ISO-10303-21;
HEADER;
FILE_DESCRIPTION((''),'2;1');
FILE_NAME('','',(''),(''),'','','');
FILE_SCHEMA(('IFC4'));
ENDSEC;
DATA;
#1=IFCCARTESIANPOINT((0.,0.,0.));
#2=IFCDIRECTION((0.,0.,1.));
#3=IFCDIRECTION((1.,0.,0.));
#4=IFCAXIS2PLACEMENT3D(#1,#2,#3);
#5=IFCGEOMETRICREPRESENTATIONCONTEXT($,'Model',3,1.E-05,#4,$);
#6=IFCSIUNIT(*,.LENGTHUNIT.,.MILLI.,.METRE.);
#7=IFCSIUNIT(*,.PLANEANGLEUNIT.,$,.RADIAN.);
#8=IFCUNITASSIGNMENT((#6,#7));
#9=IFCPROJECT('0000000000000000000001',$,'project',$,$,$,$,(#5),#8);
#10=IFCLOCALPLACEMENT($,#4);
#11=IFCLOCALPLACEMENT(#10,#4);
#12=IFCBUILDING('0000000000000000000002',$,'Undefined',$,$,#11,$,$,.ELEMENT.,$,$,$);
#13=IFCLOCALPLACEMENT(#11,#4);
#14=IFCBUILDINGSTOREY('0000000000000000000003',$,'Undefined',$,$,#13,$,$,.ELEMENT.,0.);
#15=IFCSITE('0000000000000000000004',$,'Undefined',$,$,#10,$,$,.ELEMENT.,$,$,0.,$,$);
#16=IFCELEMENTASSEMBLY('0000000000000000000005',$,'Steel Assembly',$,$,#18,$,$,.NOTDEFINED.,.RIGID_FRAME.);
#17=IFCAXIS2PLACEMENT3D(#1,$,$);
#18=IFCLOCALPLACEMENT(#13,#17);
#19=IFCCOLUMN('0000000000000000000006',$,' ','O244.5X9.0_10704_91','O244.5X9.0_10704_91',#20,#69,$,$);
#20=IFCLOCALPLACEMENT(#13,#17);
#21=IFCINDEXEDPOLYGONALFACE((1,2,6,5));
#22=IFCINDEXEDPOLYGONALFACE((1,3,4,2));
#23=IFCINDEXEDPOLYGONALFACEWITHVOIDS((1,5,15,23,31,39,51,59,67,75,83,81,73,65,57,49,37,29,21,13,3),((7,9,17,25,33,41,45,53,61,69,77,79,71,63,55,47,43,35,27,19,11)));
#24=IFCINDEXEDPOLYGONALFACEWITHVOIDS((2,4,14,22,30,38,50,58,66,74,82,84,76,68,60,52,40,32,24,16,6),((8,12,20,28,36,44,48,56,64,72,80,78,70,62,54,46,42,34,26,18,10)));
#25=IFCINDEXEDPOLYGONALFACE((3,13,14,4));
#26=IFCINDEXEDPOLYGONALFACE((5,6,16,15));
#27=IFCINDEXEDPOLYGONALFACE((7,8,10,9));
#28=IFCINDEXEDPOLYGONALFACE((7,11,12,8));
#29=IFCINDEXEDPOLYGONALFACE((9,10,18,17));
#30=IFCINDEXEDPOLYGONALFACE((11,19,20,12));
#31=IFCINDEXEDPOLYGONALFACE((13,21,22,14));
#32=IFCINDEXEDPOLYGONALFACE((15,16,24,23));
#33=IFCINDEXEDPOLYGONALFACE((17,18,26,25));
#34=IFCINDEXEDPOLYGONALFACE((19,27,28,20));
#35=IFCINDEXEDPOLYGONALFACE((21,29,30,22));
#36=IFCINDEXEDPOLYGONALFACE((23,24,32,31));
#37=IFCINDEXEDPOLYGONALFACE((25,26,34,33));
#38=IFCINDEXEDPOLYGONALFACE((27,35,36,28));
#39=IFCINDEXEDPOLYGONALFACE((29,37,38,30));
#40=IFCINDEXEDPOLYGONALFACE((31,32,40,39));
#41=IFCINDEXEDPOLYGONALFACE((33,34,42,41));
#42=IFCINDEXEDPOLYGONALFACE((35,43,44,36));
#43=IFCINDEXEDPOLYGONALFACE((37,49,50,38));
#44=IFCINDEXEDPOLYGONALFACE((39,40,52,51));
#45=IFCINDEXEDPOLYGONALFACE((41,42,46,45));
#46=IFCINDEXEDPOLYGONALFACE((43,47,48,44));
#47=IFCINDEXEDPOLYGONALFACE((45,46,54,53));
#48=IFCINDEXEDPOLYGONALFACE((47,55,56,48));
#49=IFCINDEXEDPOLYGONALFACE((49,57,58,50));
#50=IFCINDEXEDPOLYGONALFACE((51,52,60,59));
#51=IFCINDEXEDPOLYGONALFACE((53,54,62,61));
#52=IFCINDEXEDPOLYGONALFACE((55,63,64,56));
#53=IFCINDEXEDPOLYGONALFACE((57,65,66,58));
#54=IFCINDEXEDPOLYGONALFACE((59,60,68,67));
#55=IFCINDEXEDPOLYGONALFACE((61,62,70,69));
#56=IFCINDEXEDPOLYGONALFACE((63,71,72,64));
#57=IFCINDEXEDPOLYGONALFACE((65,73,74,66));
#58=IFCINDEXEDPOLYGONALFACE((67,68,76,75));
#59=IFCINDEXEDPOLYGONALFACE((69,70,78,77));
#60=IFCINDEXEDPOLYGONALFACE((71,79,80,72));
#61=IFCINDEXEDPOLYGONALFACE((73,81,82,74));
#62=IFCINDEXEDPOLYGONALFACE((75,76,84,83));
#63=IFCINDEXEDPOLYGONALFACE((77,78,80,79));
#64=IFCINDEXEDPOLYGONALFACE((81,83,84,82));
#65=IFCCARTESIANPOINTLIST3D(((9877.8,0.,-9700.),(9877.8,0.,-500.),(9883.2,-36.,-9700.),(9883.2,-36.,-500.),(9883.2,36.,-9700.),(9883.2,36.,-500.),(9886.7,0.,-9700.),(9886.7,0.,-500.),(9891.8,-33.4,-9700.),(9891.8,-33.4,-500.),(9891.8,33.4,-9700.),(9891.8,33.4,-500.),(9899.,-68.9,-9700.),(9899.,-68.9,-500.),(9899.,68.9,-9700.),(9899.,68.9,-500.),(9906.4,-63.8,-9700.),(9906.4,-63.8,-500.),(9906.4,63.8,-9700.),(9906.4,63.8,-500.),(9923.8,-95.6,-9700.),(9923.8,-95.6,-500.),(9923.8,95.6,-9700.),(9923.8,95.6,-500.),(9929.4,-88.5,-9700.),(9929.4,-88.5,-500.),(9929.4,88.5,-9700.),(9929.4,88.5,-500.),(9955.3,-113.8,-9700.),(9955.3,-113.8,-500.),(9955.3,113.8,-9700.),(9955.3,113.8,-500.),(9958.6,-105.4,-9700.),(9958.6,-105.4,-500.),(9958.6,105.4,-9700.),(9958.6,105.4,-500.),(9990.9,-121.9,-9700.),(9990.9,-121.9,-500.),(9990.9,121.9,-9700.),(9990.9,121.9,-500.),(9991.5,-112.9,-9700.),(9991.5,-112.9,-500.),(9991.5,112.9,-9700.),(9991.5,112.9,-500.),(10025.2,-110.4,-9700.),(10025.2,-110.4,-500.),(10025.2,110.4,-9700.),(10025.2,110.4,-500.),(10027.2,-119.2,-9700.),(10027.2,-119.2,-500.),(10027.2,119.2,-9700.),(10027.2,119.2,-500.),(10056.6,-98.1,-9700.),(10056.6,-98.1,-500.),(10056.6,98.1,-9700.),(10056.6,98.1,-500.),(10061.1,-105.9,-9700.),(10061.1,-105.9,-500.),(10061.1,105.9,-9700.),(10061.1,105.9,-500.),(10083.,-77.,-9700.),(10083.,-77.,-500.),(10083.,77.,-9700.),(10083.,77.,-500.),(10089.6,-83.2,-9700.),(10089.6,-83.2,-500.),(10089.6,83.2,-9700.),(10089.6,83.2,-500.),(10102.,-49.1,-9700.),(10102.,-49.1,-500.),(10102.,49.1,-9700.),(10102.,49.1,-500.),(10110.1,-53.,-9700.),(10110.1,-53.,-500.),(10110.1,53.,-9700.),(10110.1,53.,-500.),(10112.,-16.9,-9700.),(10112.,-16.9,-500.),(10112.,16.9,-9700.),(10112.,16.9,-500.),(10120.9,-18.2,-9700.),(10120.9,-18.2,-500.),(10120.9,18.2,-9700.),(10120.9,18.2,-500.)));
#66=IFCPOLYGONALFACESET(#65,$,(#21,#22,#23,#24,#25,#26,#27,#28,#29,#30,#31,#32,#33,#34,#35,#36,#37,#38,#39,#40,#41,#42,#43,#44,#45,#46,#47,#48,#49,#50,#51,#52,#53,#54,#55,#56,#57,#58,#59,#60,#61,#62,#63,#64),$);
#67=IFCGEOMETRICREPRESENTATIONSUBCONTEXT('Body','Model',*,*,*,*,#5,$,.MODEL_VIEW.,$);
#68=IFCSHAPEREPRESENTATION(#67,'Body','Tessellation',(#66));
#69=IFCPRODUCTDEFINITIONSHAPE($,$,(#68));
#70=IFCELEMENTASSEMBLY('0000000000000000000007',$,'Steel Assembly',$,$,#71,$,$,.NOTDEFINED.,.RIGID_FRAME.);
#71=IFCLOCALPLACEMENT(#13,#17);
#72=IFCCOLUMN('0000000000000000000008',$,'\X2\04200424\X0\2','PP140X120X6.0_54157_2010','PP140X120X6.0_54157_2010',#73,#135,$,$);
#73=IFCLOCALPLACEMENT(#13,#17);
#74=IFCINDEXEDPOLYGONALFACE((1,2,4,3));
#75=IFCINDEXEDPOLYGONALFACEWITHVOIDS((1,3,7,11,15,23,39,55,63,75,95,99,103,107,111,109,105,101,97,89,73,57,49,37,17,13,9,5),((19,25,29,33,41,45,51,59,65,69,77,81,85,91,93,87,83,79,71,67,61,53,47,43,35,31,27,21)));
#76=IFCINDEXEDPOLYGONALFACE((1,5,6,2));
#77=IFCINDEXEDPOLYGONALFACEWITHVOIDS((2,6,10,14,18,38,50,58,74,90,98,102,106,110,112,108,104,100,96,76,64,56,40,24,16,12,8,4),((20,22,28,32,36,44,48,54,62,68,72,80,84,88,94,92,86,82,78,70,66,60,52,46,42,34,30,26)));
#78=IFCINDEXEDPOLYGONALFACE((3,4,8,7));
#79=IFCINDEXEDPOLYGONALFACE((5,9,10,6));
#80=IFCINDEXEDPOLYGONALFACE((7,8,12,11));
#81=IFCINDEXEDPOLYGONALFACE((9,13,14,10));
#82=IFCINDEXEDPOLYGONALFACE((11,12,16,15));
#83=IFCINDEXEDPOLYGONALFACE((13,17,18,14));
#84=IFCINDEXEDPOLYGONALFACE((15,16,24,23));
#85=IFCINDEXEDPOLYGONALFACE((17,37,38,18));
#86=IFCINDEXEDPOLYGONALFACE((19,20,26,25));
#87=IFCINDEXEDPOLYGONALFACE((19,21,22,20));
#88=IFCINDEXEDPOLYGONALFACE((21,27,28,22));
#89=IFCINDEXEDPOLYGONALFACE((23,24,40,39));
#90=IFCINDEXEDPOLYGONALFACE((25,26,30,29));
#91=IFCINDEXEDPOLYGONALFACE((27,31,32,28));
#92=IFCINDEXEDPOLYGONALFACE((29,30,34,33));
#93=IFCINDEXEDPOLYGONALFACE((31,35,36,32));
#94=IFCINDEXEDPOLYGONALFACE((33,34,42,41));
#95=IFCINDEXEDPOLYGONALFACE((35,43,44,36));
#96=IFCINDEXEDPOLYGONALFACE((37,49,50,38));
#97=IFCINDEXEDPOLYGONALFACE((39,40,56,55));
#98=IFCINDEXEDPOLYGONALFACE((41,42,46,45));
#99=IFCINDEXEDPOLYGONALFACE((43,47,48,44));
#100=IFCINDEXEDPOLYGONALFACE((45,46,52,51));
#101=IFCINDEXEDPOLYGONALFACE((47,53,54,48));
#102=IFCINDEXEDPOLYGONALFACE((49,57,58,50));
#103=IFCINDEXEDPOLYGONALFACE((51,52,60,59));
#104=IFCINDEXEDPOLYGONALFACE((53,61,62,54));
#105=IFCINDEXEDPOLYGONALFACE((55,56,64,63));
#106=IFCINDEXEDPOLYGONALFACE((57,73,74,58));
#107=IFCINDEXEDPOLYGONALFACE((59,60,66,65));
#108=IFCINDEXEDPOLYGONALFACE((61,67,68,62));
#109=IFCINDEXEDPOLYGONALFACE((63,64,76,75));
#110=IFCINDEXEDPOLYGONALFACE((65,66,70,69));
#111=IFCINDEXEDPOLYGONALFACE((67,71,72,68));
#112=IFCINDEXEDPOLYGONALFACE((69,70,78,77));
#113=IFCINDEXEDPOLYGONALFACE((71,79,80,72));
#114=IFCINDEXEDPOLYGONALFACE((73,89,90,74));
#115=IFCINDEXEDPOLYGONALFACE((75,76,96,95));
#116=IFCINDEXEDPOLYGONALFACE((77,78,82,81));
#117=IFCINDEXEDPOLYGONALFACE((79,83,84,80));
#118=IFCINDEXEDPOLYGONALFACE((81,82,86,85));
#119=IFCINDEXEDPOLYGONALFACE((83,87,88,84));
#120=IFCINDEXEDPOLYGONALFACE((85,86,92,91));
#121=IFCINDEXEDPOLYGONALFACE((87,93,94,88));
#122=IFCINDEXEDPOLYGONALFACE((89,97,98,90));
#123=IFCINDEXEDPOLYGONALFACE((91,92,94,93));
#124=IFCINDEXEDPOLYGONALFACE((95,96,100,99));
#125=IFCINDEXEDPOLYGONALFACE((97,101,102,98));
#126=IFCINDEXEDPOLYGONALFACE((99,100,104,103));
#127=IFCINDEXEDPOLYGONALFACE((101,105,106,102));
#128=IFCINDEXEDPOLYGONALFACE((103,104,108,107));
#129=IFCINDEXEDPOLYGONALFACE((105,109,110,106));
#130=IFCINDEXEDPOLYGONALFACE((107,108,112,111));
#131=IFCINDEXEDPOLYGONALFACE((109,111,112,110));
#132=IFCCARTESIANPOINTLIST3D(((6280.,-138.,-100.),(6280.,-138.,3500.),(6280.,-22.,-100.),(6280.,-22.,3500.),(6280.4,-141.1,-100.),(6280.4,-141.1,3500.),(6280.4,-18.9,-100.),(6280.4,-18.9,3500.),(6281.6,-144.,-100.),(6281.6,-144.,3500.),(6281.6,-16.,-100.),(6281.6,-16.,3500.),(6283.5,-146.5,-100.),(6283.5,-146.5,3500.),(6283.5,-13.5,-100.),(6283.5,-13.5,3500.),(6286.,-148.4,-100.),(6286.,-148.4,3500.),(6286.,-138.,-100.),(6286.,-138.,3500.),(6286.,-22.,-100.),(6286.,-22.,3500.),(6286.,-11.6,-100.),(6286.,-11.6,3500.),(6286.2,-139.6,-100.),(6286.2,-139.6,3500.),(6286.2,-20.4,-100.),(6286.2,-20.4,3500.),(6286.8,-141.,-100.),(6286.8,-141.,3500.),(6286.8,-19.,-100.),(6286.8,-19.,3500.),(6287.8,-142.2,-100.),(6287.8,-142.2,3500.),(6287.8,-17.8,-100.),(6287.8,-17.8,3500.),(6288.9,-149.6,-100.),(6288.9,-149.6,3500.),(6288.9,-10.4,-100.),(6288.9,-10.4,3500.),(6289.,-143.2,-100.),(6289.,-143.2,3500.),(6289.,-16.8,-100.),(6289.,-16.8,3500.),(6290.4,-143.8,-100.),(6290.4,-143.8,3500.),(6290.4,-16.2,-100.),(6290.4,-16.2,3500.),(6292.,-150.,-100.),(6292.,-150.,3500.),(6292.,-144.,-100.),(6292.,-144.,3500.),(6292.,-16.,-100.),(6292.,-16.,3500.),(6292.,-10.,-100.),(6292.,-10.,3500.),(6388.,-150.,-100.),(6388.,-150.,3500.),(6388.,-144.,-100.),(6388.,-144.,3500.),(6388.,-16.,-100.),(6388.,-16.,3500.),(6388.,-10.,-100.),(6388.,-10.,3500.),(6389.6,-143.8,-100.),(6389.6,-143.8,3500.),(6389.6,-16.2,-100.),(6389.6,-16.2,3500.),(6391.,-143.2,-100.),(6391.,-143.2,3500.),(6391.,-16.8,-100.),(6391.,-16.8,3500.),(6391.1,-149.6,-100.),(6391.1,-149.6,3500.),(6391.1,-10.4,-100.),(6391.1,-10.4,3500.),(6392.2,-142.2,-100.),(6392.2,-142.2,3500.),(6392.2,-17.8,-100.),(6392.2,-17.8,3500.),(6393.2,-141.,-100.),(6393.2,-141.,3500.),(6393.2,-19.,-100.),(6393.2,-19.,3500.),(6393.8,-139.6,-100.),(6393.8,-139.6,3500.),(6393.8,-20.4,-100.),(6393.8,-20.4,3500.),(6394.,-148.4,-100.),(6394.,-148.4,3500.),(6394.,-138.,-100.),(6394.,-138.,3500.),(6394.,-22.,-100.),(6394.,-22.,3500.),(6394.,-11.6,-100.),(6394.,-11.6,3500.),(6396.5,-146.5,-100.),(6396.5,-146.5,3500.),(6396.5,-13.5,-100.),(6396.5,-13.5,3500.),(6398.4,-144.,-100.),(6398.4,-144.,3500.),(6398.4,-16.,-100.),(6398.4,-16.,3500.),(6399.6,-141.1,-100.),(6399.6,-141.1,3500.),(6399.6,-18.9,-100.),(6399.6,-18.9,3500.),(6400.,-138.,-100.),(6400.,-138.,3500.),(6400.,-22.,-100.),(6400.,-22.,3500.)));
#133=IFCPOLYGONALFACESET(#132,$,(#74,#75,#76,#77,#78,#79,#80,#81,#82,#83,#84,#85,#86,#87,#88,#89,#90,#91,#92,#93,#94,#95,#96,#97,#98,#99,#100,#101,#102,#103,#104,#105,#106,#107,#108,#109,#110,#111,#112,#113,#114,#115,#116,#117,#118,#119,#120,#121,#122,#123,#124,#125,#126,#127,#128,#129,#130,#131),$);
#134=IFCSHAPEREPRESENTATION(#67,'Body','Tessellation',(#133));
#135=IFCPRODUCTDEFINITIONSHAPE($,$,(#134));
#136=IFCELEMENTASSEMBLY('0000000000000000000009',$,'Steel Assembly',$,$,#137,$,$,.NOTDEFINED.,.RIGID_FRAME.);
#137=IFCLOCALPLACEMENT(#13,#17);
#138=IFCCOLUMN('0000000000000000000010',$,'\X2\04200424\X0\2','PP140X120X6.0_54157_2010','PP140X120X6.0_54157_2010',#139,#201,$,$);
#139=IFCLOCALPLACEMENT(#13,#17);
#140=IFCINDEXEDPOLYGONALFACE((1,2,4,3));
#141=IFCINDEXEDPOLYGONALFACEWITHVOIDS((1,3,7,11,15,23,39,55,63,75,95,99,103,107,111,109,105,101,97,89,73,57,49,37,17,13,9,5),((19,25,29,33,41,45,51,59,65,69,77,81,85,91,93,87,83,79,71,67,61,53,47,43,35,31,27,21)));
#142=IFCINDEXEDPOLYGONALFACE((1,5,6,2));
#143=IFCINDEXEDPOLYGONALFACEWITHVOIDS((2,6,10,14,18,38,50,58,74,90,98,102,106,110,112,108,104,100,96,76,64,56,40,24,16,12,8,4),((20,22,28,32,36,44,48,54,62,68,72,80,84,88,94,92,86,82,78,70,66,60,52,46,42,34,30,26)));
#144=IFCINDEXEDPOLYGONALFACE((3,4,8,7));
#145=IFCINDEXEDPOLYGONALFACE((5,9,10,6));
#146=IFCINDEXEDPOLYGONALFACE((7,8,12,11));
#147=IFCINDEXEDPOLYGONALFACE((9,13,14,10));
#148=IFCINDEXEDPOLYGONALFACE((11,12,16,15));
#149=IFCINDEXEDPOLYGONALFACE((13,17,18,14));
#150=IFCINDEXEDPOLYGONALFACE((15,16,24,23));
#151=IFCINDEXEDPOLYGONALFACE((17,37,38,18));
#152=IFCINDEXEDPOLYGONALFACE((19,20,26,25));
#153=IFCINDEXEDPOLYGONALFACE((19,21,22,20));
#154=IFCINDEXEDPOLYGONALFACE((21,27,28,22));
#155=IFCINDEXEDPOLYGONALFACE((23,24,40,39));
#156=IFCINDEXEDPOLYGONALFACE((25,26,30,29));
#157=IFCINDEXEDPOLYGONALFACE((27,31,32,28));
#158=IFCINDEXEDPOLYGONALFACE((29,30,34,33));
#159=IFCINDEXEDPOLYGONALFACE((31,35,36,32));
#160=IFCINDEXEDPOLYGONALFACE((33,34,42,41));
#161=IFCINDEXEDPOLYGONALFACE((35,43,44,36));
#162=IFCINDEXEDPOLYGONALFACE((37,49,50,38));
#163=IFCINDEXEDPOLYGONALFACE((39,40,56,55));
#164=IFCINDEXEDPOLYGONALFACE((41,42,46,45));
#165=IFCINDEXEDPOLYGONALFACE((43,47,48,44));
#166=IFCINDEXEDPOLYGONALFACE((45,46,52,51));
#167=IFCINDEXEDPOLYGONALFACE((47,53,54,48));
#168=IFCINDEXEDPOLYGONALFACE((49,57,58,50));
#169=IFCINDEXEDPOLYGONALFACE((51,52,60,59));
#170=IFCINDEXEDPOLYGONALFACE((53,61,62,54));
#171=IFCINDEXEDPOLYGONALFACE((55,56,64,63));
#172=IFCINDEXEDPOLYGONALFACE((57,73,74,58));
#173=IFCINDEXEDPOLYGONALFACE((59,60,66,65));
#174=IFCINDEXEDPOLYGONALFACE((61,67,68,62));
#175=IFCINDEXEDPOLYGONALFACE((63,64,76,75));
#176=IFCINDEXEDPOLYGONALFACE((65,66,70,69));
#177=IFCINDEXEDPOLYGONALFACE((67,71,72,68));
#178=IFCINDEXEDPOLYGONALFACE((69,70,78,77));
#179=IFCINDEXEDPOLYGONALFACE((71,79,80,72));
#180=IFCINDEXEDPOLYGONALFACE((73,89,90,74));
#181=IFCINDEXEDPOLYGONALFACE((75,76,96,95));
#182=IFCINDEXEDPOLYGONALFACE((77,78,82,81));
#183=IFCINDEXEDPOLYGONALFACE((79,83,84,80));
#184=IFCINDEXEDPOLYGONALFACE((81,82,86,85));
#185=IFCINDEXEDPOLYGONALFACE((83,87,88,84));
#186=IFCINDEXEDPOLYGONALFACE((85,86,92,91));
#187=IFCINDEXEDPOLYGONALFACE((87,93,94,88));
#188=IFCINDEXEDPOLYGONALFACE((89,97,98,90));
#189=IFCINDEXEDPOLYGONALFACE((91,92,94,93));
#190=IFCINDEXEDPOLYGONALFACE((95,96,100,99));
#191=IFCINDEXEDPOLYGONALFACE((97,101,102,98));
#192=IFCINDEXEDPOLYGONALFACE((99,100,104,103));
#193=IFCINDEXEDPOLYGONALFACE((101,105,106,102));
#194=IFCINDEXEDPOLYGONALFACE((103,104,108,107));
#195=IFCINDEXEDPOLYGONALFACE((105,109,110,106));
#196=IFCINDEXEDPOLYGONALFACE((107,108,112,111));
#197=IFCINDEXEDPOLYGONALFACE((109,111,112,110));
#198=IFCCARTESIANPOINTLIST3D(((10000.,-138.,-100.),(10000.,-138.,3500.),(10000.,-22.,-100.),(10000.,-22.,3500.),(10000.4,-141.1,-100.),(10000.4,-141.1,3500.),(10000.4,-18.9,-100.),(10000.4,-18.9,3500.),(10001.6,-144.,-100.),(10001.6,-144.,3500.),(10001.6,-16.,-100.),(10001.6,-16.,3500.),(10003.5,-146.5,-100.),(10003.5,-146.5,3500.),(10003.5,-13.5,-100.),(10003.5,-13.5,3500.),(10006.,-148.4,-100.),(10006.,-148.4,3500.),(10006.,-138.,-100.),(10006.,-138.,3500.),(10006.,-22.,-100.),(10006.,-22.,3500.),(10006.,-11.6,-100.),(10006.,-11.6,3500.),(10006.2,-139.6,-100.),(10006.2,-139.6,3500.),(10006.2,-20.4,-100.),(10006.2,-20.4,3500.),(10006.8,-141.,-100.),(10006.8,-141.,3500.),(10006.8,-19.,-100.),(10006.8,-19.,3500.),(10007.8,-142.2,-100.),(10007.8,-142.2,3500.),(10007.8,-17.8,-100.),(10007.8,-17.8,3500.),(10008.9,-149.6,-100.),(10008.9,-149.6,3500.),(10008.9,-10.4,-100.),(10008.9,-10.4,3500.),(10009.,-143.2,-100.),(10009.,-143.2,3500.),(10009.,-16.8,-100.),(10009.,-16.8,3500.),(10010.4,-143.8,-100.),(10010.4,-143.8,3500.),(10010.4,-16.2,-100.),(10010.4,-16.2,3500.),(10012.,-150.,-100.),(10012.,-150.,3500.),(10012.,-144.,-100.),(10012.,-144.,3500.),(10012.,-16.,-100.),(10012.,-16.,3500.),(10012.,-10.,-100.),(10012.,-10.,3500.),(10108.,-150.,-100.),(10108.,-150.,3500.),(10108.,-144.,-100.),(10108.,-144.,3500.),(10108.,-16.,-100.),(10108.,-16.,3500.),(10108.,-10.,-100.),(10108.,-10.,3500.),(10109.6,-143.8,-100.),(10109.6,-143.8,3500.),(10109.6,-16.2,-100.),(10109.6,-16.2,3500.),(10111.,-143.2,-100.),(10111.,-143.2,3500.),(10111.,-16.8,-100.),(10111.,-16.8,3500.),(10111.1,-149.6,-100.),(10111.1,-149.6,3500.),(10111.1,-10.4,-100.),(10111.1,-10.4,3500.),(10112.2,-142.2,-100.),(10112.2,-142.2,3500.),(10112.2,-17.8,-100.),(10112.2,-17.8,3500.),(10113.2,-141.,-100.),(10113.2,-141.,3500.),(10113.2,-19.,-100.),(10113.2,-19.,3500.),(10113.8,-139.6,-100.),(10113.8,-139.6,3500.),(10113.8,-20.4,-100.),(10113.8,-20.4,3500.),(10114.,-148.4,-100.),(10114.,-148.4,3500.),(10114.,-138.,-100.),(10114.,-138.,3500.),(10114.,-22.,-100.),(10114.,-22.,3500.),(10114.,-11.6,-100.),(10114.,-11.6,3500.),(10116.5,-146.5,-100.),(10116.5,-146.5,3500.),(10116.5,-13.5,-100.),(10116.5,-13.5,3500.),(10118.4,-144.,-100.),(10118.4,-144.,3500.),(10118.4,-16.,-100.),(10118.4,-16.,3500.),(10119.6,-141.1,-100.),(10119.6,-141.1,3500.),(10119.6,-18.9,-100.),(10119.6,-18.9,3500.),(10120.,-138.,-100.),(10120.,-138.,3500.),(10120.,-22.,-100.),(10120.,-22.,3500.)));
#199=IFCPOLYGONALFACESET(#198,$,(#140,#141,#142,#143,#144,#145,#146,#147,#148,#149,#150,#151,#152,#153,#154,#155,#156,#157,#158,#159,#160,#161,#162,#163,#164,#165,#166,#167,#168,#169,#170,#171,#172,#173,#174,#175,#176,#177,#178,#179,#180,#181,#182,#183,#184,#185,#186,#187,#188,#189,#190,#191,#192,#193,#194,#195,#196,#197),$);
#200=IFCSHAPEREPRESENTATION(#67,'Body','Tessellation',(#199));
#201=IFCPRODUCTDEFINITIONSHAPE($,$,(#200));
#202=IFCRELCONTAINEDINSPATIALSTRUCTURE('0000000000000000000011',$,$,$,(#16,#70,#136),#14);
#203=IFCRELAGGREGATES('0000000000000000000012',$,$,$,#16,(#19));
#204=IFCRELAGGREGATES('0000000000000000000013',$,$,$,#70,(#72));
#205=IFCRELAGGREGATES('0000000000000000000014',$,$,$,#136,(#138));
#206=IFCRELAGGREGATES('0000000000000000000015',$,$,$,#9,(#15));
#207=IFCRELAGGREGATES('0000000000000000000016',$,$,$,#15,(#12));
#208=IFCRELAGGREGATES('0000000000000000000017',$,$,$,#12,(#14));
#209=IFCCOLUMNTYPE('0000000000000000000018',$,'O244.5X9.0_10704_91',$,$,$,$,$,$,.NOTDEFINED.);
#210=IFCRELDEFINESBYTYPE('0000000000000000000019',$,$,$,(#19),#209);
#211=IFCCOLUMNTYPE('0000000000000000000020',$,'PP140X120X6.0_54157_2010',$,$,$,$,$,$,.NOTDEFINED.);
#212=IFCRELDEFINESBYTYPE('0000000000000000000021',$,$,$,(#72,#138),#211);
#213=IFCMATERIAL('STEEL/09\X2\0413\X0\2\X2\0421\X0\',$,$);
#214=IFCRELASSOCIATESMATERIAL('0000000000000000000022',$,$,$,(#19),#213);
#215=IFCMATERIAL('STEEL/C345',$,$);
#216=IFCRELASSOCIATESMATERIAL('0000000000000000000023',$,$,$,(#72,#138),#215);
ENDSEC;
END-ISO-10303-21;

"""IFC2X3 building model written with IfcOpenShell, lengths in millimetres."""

from ifc_helpers import new_model, si_unit, frame, origin_with_axes, origin_2d_with_axis, place, context, subcontext, project, spatial, hollow_rectangle, hollow_circle, extrude, material, type_object, element, aggregate, save


model = new_model("IFC2X3")

# Units and contexts
model_context = context("Model", 3, precision=1e-05, world=origin_with_axes())
body_context = subcontext(model_context, "Body", "Model", "MODEL_VIEW")
ifc_project = project(units=[si_unit("LENGTHUNIT", "METRE", prefix="MILLI"), si_unit("PLANEANGLEUNIT", "RADIAN")], contexts=[model_context])

# Site, building, storey
site_placement = place(None, origin_with_axes())
site = spatial("IfcSite", under=ifc_project, at=site_placement, Name="Undefined", CompositionType="ELEMENT", RefElevation=0.0)
building_placement = place(site_placement, origin_with_axes())
building = spatial("IfcBuilding", under=site, at=building_placement, Name="Undefined", CompositionType="ELEMENT")
storey_placement = place(building_placement, origin_with_axes())
storey = spatial("IfcBuildingStorey", under=building, at=storey_placement, Name="Undefined", CompositionType="ELEMENT", Elevation=0.0)

# Element assemblies, columns
ifc_material_1 = material(Name="STEEL/09Г2С")
column_type_1 = type_object("IfcColumnType", Name="O244.5X9.0_10704_91", PredefinedType="NOTDEFINED")
assembly_1_placement = place(storey_placement, origin_with_axes())
assembly_1 = element("IfcElementAssembly", 1, at=assembly_1_placement, inside=storey, Name="Steel Assembly", AssemblyPlace="NOTDEFINED", PredefinedType="RIGID_FRAME")
column_1_placement = place(assembly_1_placement, frame((10000.0, 0.0, -9700.0), z_axis=(0.0, 0.0, 1.0), x_axis=(0.0, 1.0, 0.0)))
column_1 = element("IfcColumn", 2, at=column_1_placement, type_object=column_type_1, material=ifc_material_1, Name=" ", Description="O244.5X9.0_10704_91", ObjectType="O244.5X9.0_10704_91", context=body_context, shape_type="SweptSolid", body=[
    extrude(hollow_circle(Radius=122.2, WallThickness=9.0, at=origin_2d_with_axis()), frame((0.0, 0.0, 9200.0), z_axis=(0.0, 0.0, -1.0), x_axis=(0.0, 1.0, 0.0)), (0.0, 0.0, 1.0), 9200.0),
])
aggregate(assembly_1, [column_1])
assembly_2_placement = place(storey_placement, origin_with_axes())
assembly_2 = element("IfcElementAssembly", 3, at=assembly_2_placement, inside=storey, Name="Steel Assembly", AssemblyPlace="NOTDEFINED", PredefinedType="RIGID_FRAME")
ifc_material_2 = material(Name="STEEL/C345")
column_type_2 = type_object("IfcColumnType", Name="PP140X120X6.0_54157_2010", PredefinedType="NOTDEFINED")
column_2_placement = place(assembly_2_placement, frame((6340.0, -80.0, -100.0), z_axis=(0.0, 0.0, 1.0), x_axis=(0.0, 1.0, 0.0)))
column_2 = element("IfcColumn", 4, at=column_2_placement, type_object=column_type_2, material=ifc_material_2, Name="РФ2", Description="PP140X120X6.0_54157_2010", ObjectType="PP140X120X6.0_54157_2010", context=body_context, shape_type="SweptSolid", body=[
    extrude(hollow_rectangle(XDim=120.0, YDim=140.0, WallThickness=6.0, InnerFilletRadius=6.0, OuterFilletRadius=12.0, at=origin_2d_with_axis()), frame((0.0, 0.0, 3600.0), z_axis=(0.0, 0.0, -1.0), x_axis=(0.0, 1.0, 0.0)), (0.0, 0.0, 1.0), 3600.0),
])
aggregate(assembly_2, [column_2])
assembly_3_placement = place(storey_placement, origin_with_axes())
assembly_3 = element("IfcElementAssembly", 5, at=assembly_3_placement, inside=storey, Name="Steel Assembly", AssemblyPlace="NOTDEFINED", PredefinedType="RIGID_FRAME")
column_3_placement = place(assembly_3_placement, frame((10060.0, -80.0, -100.0), z_axis=(0.0, 0.0, 1.0), x_axis=(0.0, 1.0, 0.0)))
column_3 = element("IfcColumn", 6, at=column_3_placement, type_object=column_type_2, material=ifc_material_2, Name="РФ2", Description="PP140X120X6.0_54157_2010", ObjectType="PP140X120X6.0_54157_2010", context=body_context, shape_type="SweptSolid", body=[
    extrude(hollow_rectangle(XDim=120.0, YDim=140.0, WallThickness=6.0, InnerFilletRadius=6.0, OuterFilletRadius=12.0, at=origin_2d_with_axis()), frame((0.0, 0.0, 3600.0), z_axis=(0.0, 0.0, -1.0), x_axis=(0.0, 1.0, 0.0)), (0.0, 0.0, 1.0), 3600.0),
])
aggregate(assembly_3, [column_3])

save(model, "model.ifc")
